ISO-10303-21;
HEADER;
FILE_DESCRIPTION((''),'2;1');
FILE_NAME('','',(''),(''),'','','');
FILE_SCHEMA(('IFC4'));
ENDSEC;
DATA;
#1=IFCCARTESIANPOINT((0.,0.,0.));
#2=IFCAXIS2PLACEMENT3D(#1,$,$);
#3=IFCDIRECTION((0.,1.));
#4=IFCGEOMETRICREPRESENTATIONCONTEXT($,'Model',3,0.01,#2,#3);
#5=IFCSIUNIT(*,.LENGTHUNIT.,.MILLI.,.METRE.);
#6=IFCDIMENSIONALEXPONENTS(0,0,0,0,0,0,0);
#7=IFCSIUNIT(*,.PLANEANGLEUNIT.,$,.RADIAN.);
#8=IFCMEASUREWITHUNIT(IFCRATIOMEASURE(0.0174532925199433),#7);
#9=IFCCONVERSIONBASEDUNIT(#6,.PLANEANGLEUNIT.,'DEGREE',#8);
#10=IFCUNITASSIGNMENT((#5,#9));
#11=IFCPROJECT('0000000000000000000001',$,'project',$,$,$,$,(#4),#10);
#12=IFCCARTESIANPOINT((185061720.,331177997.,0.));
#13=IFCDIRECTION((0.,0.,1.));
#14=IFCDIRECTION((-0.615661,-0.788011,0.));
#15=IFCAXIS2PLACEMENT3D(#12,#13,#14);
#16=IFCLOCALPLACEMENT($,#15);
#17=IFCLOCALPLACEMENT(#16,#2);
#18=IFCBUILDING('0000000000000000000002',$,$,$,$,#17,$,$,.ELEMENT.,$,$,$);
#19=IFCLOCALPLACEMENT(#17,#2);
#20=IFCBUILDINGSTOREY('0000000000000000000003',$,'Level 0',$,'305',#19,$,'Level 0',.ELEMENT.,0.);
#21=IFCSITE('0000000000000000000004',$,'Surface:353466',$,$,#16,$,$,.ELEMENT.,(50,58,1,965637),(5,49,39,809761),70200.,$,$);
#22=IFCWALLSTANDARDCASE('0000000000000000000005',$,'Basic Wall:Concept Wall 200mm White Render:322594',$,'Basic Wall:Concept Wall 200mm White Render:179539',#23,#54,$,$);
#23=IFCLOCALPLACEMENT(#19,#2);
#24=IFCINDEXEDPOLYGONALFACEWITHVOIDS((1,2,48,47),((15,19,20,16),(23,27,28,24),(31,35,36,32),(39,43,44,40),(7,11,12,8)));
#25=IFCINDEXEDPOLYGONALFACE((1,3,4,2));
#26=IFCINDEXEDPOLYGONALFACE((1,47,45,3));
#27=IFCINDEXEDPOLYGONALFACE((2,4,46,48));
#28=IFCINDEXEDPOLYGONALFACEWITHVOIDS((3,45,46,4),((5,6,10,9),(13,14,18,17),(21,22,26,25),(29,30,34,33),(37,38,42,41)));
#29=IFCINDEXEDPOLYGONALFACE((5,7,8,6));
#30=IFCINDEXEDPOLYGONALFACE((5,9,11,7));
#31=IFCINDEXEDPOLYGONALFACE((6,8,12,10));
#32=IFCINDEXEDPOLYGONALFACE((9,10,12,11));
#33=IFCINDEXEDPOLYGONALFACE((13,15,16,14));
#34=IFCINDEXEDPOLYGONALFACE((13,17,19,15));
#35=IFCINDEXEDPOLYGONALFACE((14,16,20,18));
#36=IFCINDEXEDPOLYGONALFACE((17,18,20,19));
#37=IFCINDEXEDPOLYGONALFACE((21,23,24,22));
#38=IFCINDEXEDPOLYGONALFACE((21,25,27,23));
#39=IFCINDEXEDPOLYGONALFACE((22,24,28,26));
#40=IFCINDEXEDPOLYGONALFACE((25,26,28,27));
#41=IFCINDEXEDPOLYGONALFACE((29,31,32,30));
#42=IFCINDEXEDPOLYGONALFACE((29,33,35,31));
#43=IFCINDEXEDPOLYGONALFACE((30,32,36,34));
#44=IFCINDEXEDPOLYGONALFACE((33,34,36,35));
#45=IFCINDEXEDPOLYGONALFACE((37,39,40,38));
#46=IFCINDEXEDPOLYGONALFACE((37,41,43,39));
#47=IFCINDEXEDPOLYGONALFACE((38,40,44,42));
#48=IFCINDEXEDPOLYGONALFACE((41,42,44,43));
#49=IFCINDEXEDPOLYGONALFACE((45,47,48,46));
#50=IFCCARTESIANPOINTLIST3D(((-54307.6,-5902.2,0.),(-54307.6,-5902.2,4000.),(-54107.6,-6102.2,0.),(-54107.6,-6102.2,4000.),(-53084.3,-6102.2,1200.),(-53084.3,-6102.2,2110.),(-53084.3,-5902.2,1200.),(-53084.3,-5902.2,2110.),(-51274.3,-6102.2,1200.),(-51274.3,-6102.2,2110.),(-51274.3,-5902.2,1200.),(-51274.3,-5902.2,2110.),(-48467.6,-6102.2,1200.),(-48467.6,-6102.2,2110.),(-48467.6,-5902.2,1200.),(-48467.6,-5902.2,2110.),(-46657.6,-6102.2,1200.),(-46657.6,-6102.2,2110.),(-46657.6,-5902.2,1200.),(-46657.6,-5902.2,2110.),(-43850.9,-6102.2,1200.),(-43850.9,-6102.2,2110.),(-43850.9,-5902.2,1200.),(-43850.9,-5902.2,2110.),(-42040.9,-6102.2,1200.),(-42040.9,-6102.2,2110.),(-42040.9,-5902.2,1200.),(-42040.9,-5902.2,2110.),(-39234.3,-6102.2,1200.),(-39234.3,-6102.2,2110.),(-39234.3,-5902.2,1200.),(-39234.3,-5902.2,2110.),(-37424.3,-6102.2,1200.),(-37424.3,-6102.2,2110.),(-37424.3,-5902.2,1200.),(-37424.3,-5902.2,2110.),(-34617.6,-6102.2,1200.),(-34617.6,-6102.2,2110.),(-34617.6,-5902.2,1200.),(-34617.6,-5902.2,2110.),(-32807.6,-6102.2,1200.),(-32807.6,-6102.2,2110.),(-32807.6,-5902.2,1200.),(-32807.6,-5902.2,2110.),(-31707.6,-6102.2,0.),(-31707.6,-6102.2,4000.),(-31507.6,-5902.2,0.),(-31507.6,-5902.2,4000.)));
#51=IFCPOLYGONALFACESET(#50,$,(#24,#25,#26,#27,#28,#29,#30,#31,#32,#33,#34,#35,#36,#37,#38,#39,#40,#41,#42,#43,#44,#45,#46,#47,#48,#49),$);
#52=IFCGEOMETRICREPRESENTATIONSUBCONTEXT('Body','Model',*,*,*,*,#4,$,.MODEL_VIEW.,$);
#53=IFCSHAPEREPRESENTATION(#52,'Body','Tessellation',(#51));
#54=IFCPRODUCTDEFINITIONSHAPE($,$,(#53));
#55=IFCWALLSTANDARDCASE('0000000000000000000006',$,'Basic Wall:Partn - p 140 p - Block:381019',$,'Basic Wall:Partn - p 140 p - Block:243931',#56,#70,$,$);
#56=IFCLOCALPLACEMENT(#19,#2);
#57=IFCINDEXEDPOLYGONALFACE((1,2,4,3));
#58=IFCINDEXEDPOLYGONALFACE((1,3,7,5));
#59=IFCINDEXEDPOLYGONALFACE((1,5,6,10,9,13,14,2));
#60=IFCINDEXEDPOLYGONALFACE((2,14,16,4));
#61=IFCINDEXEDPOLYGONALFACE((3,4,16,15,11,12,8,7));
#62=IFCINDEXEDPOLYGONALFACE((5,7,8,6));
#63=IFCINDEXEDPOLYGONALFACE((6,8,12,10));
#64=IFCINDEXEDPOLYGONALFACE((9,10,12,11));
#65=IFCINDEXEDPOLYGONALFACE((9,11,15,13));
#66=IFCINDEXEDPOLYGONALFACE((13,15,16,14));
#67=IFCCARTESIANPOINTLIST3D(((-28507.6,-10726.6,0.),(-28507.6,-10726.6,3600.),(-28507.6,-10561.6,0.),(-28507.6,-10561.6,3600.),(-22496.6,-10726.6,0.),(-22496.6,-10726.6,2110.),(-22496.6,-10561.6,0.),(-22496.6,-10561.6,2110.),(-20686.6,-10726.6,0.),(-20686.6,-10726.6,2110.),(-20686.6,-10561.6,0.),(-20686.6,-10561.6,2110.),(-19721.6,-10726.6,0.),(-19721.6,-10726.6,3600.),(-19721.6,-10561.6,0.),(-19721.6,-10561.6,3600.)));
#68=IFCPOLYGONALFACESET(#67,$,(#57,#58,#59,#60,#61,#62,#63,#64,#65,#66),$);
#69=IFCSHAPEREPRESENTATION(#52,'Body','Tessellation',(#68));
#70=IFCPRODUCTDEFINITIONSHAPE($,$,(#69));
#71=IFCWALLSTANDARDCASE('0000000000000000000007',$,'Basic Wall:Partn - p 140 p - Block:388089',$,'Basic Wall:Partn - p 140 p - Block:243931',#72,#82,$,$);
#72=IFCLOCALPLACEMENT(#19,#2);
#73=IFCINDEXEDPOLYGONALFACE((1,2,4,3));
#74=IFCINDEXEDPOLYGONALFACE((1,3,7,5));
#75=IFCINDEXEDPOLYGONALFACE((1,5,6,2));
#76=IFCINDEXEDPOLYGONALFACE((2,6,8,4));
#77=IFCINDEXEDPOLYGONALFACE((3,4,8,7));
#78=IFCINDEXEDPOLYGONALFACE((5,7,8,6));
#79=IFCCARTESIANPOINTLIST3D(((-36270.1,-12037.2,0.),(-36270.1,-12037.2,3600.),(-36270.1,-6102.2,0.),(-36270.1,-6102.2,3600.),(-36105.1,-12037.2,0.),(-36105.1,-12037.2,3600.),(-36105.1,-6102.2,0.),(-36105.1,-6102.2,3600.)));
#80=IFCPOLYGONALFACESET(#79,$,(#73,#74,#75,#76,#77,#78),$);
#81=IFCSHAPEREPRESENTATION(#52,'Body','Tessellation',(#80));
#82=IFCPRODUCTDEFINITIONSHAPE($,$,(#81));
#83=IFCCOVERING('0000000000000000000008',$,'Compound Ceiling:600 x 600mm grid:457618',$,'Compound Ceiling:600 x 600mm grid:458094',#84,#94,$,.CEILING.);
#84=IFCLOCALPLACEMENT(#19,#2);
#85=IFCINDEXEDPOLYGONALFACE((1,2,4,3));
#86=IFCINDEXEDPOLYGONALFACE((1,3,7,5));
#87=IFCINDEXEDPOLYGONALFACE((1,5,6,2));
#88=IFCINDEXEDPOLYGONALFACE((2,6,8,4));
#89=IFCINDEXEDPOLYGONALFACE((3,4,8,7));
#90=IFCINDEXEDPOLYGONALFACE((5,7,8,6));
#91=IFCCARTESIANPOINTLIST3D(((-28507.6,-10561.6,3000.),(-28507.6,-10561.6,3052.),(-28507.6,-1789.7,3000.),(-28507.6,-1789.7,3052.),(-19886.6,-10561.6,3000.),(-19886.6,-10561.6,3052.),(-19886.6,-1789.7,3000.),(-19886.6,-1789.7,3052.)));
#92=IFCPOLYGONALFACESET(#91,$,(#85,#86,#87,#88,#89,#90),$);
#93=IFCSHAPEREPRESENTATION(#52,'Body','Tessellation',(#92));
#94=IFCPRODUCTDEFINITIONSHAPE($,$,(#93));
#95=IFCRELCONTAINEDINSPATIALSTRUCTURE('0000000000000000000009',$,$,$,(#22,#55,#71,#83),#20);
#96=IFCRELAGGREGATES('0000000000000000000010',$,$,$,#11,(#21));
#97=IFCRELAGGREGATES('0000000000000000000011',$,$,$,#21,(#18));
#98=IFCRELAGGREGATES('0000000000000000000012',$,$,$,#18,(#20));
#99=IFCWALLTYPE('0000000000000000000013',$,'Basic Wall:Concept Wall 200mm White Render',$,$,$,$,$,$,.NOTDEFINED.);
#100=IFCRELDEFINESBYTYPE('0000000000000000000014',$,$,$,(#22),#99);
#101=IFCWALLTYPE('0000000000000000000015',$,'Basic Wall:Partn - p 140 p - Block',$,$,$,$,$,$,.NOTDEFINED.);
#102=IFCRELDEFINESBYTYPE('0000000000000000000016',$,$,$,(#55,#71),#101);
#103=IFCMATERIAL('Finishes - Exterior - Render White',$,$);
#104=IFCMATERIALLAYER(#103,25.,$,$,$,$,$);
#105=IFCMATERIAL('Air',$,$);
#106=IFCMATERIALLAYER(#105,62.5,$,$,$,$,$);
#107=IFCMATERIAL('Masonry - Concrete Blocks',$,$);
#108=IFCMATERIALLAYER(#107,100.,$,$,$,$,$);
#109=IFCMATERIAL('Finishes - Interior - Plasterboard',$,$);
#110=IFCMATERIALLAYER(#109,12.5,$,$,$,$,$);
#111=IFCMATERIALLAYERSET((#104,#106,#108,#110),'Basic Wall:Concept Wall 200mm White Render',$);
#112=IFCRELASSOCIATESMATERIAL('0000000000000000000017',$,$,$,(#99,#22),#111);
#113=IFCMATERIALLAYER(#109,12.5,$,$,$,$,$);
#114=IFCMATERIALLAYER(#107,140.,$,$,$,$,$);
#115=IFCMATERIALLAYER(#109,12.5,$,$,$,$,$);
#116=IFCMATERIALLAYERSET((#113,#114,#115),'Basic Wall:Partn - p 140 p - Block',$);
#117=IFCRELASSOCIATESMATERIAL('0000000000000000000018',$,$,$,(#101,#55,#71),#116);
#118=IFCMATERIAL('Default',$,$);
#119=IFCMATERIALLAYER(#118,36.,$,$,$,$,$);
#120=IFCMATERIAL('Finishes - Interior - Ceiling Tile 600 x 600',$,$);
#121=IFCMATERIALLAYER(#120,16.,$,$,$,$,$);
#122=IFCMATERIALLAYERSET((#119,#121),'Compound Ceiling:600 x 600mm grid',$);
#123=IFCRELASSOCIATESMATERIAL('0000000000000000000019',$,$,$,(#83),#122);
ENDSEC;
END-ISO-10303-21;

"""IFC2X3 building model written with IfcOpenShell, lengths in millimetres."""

from ifc_helpers import new_model, entity, si_unit, converted_unit, direction, frame, frame_2d, origin, place, context, subcontext, project, spatial, polyline, rectangle, outline, extrude, clip, halfspace, bounded_halfspace, material, layer, layer_set, layer_usage, type_object, element, save


model = new_model("IFC2X3")

# Units and contexts
model_context = context("Model", 3, precision=0.01, world=origin(), true_north=direction((0.0, 1.0)))
body_context = subcontext(model_context, "Body", "Model", "MODEL_VIEW")
ifc_project = project(units=[si_unit("LENGTHUNIT", "METRE", prefix="MILLI"), converted_unit("PLANEANGLEUNIT", "DEGREE", entity("IfcRatioMeasure", 0.0174532925199433), si_unit("PLANEANGLEUNIT", "RADIAN"), dimensions=[0, 0, 0, 0, 0, 0, 0])], contexts=[model_context])

# Site, building, storey
site_placement = place(None, frame((185061720.0, 331177997.0, 0.0), z_axis=(0.0, 0.0, 1.0), x_axis=(-0.615661, -0.788011, 0.0)))
site = spatial("IfcSite", under=ifc_project, at=site_placement, Name="Surface:353466", CompositionType="ELEMENT", RefLatitude=(50, 58, 1, 965637), RefLongitude=(5, 49, 39, 809761), RefElevation=70200.0)
building_placement = place(site_placement, origin())
building = spatial("IfcBuilding", under=site, at=building_placement, CompositionType="ELEMENT")
storey_placement = place(building_placement, origin())
storey = spatial("IfcBuildingStorey", under=building, at=storey_placement, Name="Level 0", ObjectType="305", LongName="Level 0", CompositionType="ELEMENT", Elevation=0.0)

# Shared definitions
ifc_material_1 = material(Name="Masonry - Concrete Blocks")
ifc_material_2 = material(Name="Finishes - Interior - Plasterboard")

# Walls, openings
ifc_material_3 = material(Name="Finishes - Exterior - Render White")
ifc_layer_1 = layer(ifc_material_3, 25.0)
ifc_material_4 = material(Name="Air")
ifc_layer_2 = layer(ifc_material_4, 62.5)
ifc_layer_3 = layer(ifc_material_1, 100.0)
ifc_layer_4 = layer(ifc_material_2, 12.5)
ifc_layer_set_1 = layer_set([ifc_layer_1, ifc_layer_2, ifc_layer_3, ifc_layer_4], Name="Basic Wall:Concept Wall 200mm White Render")
wall_type_1 = type_object("IfcWallType", Name="Basic Wall:Concept Wall 200mm White Render", PredefinedType="NOTDEFINED", material=ifc_layer_set_1)
ifc_layer_usage_1 = layer_usage(ifc_layer_set_1, "AXIS2", "POSITIVE", -100.0)
wall_1_placement = place(storey_placement, frame((-31507.6, -6002.2, 0.0), z_axis=(0.0, 0.0, 1.0), x_axis=(-1.0, 0.0, 0.0)))
wall_1 = element("IfcWallStandardCase", 1, at=wall_1_placement, inside=storey, type_object=wall_type_1, material=ifc_layer_usage_1, Name="Basic Wall:Concept Wall 200mm White Render:322594", ObjectType="Basic Wall:Concept Wall 200mm White Render:179539", context=body_context, shape_type="Clipping", body=[
    clip(extrude(outline(polyline([(22800.0, -100.0), (22600.0, 100.0), (13722.5, 100.0), (13557.5, 100.0), (4762.5, 100.0), (4597.5, 100.0), (200.0, 100.0), (0.0, -100.0), (22800.0, -100.0)])), origin(), (0.0, 0.0, 1.0), 4000.0), halfspace(origin(), True)),
])
opening_1_placement = place(wall_1_placement, frame((3110.0, 1624.0, 1200.0)))
element("IfcOpeningElement", 2, at=opening_1_placement, cuts=wall_1, ObjectType="Opening", context=body_context, shape_type="SweptSolid", body=[
    extrude(rectangle(XDim=910.0, YDim=1810.0, at=frame_2d((0.0, 0.0), x_axis=(1.0, 0.0))), frame((-905.0, -3048.0, 455.0), z_axis=(0.0, 1.0, 0.0), x_axis=(0.0, 0.0, -1.0)), (0.0, 0.0, 1.0), 3048.0),
])
opening_2_placement = place(wall_1_placement, frame((7726.7, 1624.0, 1200.0)))
element("IfcOpeningElement", 3, at=opening_2_placement, cuts=wall_1, ObjectType="Opening", context=body_context, shape_type="SweptSolid", body=[
    extrude(rectangle(XDim=910.0, YDim=1810.0, at=frame_2d((0.0, 0.0), x_axis=(1.0, 0.0))), frame((-905.0, -3048.0, 455.0), z_axis=(0.0, 1.0, 0.0), x_axis=(0.0, 0.0, -1.0)), (0.0, 0.0, 1.0), 3048.0),
])
opening_3_placement = place(wall_1_placement, frame((16960.0, 1624.0, 1200.0)))
element("IfcOpeningElement", 4, at=opening_3_placement, cuts=wall_1, ObjectType="Opening", context=body_context, shape_type="SweptSolid", body=[
    extrude(rectangle(XDim=910.0, YDim=1810.0, at=frame_2d((0.0, 0.0), x_axis=(1.0, 0.0))), frame((-905.0, -3048.0, 455.0), z_axis=(0.0, 1.0, 0.0), x_axis=(0.0, 0.0, -1.0)), (0.0, 0.0, 1.0), 3048.0),
])
opening_4_placement = place(wall_1_placement, frame((12343.4, 1624.0, 1200.0)))
element("IfcOpeningElement", 5, at=opening_4_placement, cuts=wall_1, ObjectType="Opening", context=body_context, shape_type="SweptSolid", body=[
    extrude(rectangle(XDim=910.0, YDim=1810.0, at=frame_2d((0.0, 0.0), x_axis=(1.0, 0.0))), frame((-905.0, -3048.0, 455.0), z_axis=(0.0, 1.0, 0.0), x_axis=(0.0, 0.0, -1.0)), (0.0, 0.0, 1.0), 3048.0),
])
opening_5_placement = place(wall_1_placement, frame((21576.7, 1624.0, 1200.0)))
element("IfcOpeningElement", 6, at=opening_5_placement, cuts=wall_1, ObjectType="Opening", context=body_context, shape_type="SweptSolid", body=[
    extrude(rectangle(XDim=910.0, YDim=1810.0, at=frame_2d((0.0, 0.0), x_axis=(1.0, 0.0))), frame((-905.0, -3048.0, 455.0), z_axis=(0.0, 1.0, 0.0), x_axis=(0.0, 0.0, -1.0)), (0.0, 0.0, 1.0), 3048.0),
])
opening_6_placement = place(wall_1_placement, frame((3110.0, 100.0, 1200.0)))
element("IfcOpeningElement", 7, at=opening_6_placement, cuts=wall_1, ObjectType="Opening", context=body_context, shape_type="SweptSolid", body=[
    extrude(rectangle(XDim=910.0, YDim=1810.0, at=frame_2d((455.0, 905.0), x_axis=(-1.0, 0.0))), frame((0.0, 0.0, 0.0), z_axis=(0.0, -1.0, 0.0), x_axis=(0.0, 0.0, 1.0)), (0.0, 0.0, 1.0), 200.0),
])
opening_7_placement = place(wall_1_placement, frame((7726.7, 100.0, 1200.0)))
element("IfcOpeningElement", 8, at=opening_7_placement, cuts=wall_1, ObjectType="Opening", context=body_context, shape_type="SweptSolid", body=[
    extrude(rectangle(XDim=910.0, YDim=1810.0, at=frame_2d((455.0, 905.0), x_axis=(-1.0, 0.0))), frame((0.0, 0.0, 0.0), z_axis=(0.0, -1.0, 0.0), x_axis=(0.0, 0.0, 1.0)), (0.0, 0.0, 1.0), 200.0),
])
opening_8_placement = place(wall_1_placement, frame((12343.4, 100.0, 1200.0)))
element("IfcOpeningElement", 9, at=opening_8_placement, cuts=wall_1, ObjectType="Opening", context=body_context, shape_type="SweptSolid", body=[
    extrude(rectangle(XDim=910.0, YDim=1810.0, at=frame_2d((455.0, 905.0), x_axis=(-1.0, 0.0))), frame((0.0, 0.0, 0.0), z_axis=(0.0, -1.0, 0.0), x_axis=(0.0, 0.0, 1.0)), (0.0, 0.0, 1.0), 200.0),
])
opening_9_placement = place(wall_1_placement, frame((16960.0, 100.0, 1200.0)))
element("IfcOpeningElement", 10, at=opening_9_placement, cuts=wall_1, ObjectType="Opening", context=body_context, shape_type="SweptSolid", body=[
    extrude(rectangle(XDim=910.0, YDim=1810.0, at=frame_2d((455.0, 905.0), x_axis=(-1.0, 0.0))), frame((0.0, 0.0, 0.0), z_axis=(0.0, -1.0, 0.0), x_axis=(0.0, 0.0, 1.0)), (0.0, 0.0, 1.0), 200.0),
])
opening_10_placement = place(wall_1_placement, frame((21576.7, 100.0, 1200.0)))
element("IfcOpeningElement", 11, at=opening_10_placement, cuts=wall_1, ObjectType="Opening", context=body_context, shape_type="SweptSolid", body=[
    extrude(rectangle(XDim=910.0, YDim=1810.0, at=frame_2d((455.0, 905.0), x_axis=(-1.0, 0.0))), frame((0.0, 0.0, 0.0), z_axis=(0.0, -1.0, 0.0), x_axis=(0.0, 0.0, 1.0)), (0.0, 0.0, 1.0), 200.0),
])
ifc_layer_5 = layer(ifc_material_2, 12.5)
ifc_layer_6 = layer(ifc_material_1, 140.0)
ifc_layer_7 = layer(ifc_material_2, 12.5)
ifc_layer_set_2 = layer_set([ifc_layer_5, ifc_layer_6, ifc_layer_7], Name="Basic Wall:Partn - p 140 p - Block")
ifc_layer_usage_2 = layer_usage(ifc_layer_set_2, "AXIS2", "NEGATIVE", 82.5)
wall_type_2 = type_object("IfcWallType", Name="Basic Wall:Partn - p 140 p - Block", PredefinedType="NOTDEFINED", material=ifc_layer_set_2)
wall_2_placement = place(storey_placement, frame((-28507.6, -10644.1, 0.0)))
wall_2 = element("IfcWallStandardCase", 12, at=wall_2_placement, inside=storey, type_object=wall_type_2, material=ifc_layer_usage_2, Name="Basic Wall:Partn - p 140 p - Block:381019", ObjectType="Basic Wall:Partn - p 140 p - Block:243931", context=body_context, shape_type="Clipping", body=[
    clip(extrude(rectangle(XDim=8786.0, YDim=165.0, at=frame_2d((4393.0, 0.0), x_axis=(-1.0, 0.0))), origin(), (0.0, 0.0, 1.0), 3600.0), bounded_halfspace(frame((0.0, -82.5, 3600.0), z_axis=(0.0, 0.0, -1.0), x_axis=(0.0, -1.0, 0.0)), True, frame((0.0, -82.5, 3600.0)), polyline([(0.0, 0.0), (5048.2, 0.0), (5213.2, 0.0), (8786.0, 0.0), (8786.0, 165.0), (8621.0, 165.0), (0.0, 165.0), (0.0, 0.0)]))),
])
opening_11_placement = place(wall_2_placement, frame((6011.0, -1606.5, 0.0)))
element("IfcOpeningElement", 13, at=opening_11_placement, cuts=wall_2, ObjectType="Opening", context=body_context, shape_type="SweptSolid", body=[
    extrude(rectangle(XDim=2110.0, YDim=1810.0, at=frame_2d((0.0, 0.0), x_axis=(0.0, 1.0))), frame((905.0, 0.0, 1055.0), z_axis=(0.0, 1.0, 0.0), x_axis=(-1.0, 0.0, 0.0)), (0.0, 0.0, 1.0), 3048.0),
])
opening_12_placement = place(wall_2_placement, frame((6011.0, -82.5, 0.0)))
element("IfcOpeningElement", 14, at=opening_12_placement, cuts=wall_2, ObjectType="Opening", context=body_context, shape_type="SweptSolid", body=[
    extrude(rectangle(XDim=2110.0, YDim=1810.0, at=frame_2d((1055.0, 905.0), x_axis=(1.0, 0.0))), frame((0.0, 0.0, 0.0), z_axis=(0.0, 1.0, 0.0), x_axis=(0.0, 0.0, 1.0)), (0.0, 0.0, 1.0), 165.0),
])

# Wall
ifc_layer_usage_3 = layer_usage(ifc_layer_set_2, "AXIS2", "NEGATIVE", 82.5)
wall_3_placement = place(storey_placement, frame((-36187.6, -6102.2, 0.0), z_axis=(0.0, 0.0, 1.0), x_axis=(0.0, -1.0, 0.0)))
element("IfcWallStandardCase", 15, at=wall_3_placement, inside=storey, type_object=wall_type_2, material=ifc_layer_usage_3, Name="Basic Wall:Partn - p 140 p - Block:388089", ObjectType="Basic Wall:Partn - p 140 p - Block:243931", context=body_context, shape_type="Clipping", body=[
    clip(extrude(rectangle(XDim=5935.0, YDim=165.0, at=frame_2d((2967.5, 0.0), x_axis=(-1.0, 0.0))), origin(), (0.0, 0.0, 1.0), 3600.0), bounded_halfspace(frame((0.0, -82.5, 3600.0), z_axis=(0.0, 0.0, -1.0), x_axis=(0.0, 1.0, 0.0)), True, frame((0.0, -82.5, 3600.0)), polyline([(0.0, 0.0), (5935.0, 0.0), (5935.0, 165.0), (0.0, 165.0), (0.0, 0.0)]))),
])

# Covering
ifc_material_5 = material(Name="Default")
ifc_layer_8 = layer(ifc_material_5, 36.0)
ifc_material_6 = material(Name="Finishes - Interior - Ceiling Tile 600 x 600")
ifc_layer_9 = layer(ifc_material_6, 16.0)
ifc_layer_set_3 = layer_set([ifc_layer_8, ifc_layer_9], Name="Compound Ceiling:600 x 600mm grid")
ifc_layer_usage_4 = layer_usage(ifc_layer_set_3, "AXIS3", "POSITIVE", 0.0)
covering_placement = place(storey_placement, frame((-28507.6, -10561.6, 3000.0)))
element("IfcCovering", 16, at=covering_placement, inside=storey, material=ifc_layer_usage_4, Name="Compound Ceiling:600 x 600mm grid:457618", ObjectType="Compound Ceiling:600 x 600mm grid:458094", PredefinedType="CEILING", context=body_context, shape_type="SweptSolid", body=[
    extrude(rectangle(XDim=8771.9, YDim=8621.0, at=frame_2d((0.0, 0.0), x_axis=(1.0, 0.0))), frame((4310.5, 4385.9, 0.0), z_axis=(0.0, 0.0, 1.0), x_axis=(0.0, 1.0, 0.0)), (0.0, 0.0, 1.0), 52.0),
])

save(model, "model.ifc")
